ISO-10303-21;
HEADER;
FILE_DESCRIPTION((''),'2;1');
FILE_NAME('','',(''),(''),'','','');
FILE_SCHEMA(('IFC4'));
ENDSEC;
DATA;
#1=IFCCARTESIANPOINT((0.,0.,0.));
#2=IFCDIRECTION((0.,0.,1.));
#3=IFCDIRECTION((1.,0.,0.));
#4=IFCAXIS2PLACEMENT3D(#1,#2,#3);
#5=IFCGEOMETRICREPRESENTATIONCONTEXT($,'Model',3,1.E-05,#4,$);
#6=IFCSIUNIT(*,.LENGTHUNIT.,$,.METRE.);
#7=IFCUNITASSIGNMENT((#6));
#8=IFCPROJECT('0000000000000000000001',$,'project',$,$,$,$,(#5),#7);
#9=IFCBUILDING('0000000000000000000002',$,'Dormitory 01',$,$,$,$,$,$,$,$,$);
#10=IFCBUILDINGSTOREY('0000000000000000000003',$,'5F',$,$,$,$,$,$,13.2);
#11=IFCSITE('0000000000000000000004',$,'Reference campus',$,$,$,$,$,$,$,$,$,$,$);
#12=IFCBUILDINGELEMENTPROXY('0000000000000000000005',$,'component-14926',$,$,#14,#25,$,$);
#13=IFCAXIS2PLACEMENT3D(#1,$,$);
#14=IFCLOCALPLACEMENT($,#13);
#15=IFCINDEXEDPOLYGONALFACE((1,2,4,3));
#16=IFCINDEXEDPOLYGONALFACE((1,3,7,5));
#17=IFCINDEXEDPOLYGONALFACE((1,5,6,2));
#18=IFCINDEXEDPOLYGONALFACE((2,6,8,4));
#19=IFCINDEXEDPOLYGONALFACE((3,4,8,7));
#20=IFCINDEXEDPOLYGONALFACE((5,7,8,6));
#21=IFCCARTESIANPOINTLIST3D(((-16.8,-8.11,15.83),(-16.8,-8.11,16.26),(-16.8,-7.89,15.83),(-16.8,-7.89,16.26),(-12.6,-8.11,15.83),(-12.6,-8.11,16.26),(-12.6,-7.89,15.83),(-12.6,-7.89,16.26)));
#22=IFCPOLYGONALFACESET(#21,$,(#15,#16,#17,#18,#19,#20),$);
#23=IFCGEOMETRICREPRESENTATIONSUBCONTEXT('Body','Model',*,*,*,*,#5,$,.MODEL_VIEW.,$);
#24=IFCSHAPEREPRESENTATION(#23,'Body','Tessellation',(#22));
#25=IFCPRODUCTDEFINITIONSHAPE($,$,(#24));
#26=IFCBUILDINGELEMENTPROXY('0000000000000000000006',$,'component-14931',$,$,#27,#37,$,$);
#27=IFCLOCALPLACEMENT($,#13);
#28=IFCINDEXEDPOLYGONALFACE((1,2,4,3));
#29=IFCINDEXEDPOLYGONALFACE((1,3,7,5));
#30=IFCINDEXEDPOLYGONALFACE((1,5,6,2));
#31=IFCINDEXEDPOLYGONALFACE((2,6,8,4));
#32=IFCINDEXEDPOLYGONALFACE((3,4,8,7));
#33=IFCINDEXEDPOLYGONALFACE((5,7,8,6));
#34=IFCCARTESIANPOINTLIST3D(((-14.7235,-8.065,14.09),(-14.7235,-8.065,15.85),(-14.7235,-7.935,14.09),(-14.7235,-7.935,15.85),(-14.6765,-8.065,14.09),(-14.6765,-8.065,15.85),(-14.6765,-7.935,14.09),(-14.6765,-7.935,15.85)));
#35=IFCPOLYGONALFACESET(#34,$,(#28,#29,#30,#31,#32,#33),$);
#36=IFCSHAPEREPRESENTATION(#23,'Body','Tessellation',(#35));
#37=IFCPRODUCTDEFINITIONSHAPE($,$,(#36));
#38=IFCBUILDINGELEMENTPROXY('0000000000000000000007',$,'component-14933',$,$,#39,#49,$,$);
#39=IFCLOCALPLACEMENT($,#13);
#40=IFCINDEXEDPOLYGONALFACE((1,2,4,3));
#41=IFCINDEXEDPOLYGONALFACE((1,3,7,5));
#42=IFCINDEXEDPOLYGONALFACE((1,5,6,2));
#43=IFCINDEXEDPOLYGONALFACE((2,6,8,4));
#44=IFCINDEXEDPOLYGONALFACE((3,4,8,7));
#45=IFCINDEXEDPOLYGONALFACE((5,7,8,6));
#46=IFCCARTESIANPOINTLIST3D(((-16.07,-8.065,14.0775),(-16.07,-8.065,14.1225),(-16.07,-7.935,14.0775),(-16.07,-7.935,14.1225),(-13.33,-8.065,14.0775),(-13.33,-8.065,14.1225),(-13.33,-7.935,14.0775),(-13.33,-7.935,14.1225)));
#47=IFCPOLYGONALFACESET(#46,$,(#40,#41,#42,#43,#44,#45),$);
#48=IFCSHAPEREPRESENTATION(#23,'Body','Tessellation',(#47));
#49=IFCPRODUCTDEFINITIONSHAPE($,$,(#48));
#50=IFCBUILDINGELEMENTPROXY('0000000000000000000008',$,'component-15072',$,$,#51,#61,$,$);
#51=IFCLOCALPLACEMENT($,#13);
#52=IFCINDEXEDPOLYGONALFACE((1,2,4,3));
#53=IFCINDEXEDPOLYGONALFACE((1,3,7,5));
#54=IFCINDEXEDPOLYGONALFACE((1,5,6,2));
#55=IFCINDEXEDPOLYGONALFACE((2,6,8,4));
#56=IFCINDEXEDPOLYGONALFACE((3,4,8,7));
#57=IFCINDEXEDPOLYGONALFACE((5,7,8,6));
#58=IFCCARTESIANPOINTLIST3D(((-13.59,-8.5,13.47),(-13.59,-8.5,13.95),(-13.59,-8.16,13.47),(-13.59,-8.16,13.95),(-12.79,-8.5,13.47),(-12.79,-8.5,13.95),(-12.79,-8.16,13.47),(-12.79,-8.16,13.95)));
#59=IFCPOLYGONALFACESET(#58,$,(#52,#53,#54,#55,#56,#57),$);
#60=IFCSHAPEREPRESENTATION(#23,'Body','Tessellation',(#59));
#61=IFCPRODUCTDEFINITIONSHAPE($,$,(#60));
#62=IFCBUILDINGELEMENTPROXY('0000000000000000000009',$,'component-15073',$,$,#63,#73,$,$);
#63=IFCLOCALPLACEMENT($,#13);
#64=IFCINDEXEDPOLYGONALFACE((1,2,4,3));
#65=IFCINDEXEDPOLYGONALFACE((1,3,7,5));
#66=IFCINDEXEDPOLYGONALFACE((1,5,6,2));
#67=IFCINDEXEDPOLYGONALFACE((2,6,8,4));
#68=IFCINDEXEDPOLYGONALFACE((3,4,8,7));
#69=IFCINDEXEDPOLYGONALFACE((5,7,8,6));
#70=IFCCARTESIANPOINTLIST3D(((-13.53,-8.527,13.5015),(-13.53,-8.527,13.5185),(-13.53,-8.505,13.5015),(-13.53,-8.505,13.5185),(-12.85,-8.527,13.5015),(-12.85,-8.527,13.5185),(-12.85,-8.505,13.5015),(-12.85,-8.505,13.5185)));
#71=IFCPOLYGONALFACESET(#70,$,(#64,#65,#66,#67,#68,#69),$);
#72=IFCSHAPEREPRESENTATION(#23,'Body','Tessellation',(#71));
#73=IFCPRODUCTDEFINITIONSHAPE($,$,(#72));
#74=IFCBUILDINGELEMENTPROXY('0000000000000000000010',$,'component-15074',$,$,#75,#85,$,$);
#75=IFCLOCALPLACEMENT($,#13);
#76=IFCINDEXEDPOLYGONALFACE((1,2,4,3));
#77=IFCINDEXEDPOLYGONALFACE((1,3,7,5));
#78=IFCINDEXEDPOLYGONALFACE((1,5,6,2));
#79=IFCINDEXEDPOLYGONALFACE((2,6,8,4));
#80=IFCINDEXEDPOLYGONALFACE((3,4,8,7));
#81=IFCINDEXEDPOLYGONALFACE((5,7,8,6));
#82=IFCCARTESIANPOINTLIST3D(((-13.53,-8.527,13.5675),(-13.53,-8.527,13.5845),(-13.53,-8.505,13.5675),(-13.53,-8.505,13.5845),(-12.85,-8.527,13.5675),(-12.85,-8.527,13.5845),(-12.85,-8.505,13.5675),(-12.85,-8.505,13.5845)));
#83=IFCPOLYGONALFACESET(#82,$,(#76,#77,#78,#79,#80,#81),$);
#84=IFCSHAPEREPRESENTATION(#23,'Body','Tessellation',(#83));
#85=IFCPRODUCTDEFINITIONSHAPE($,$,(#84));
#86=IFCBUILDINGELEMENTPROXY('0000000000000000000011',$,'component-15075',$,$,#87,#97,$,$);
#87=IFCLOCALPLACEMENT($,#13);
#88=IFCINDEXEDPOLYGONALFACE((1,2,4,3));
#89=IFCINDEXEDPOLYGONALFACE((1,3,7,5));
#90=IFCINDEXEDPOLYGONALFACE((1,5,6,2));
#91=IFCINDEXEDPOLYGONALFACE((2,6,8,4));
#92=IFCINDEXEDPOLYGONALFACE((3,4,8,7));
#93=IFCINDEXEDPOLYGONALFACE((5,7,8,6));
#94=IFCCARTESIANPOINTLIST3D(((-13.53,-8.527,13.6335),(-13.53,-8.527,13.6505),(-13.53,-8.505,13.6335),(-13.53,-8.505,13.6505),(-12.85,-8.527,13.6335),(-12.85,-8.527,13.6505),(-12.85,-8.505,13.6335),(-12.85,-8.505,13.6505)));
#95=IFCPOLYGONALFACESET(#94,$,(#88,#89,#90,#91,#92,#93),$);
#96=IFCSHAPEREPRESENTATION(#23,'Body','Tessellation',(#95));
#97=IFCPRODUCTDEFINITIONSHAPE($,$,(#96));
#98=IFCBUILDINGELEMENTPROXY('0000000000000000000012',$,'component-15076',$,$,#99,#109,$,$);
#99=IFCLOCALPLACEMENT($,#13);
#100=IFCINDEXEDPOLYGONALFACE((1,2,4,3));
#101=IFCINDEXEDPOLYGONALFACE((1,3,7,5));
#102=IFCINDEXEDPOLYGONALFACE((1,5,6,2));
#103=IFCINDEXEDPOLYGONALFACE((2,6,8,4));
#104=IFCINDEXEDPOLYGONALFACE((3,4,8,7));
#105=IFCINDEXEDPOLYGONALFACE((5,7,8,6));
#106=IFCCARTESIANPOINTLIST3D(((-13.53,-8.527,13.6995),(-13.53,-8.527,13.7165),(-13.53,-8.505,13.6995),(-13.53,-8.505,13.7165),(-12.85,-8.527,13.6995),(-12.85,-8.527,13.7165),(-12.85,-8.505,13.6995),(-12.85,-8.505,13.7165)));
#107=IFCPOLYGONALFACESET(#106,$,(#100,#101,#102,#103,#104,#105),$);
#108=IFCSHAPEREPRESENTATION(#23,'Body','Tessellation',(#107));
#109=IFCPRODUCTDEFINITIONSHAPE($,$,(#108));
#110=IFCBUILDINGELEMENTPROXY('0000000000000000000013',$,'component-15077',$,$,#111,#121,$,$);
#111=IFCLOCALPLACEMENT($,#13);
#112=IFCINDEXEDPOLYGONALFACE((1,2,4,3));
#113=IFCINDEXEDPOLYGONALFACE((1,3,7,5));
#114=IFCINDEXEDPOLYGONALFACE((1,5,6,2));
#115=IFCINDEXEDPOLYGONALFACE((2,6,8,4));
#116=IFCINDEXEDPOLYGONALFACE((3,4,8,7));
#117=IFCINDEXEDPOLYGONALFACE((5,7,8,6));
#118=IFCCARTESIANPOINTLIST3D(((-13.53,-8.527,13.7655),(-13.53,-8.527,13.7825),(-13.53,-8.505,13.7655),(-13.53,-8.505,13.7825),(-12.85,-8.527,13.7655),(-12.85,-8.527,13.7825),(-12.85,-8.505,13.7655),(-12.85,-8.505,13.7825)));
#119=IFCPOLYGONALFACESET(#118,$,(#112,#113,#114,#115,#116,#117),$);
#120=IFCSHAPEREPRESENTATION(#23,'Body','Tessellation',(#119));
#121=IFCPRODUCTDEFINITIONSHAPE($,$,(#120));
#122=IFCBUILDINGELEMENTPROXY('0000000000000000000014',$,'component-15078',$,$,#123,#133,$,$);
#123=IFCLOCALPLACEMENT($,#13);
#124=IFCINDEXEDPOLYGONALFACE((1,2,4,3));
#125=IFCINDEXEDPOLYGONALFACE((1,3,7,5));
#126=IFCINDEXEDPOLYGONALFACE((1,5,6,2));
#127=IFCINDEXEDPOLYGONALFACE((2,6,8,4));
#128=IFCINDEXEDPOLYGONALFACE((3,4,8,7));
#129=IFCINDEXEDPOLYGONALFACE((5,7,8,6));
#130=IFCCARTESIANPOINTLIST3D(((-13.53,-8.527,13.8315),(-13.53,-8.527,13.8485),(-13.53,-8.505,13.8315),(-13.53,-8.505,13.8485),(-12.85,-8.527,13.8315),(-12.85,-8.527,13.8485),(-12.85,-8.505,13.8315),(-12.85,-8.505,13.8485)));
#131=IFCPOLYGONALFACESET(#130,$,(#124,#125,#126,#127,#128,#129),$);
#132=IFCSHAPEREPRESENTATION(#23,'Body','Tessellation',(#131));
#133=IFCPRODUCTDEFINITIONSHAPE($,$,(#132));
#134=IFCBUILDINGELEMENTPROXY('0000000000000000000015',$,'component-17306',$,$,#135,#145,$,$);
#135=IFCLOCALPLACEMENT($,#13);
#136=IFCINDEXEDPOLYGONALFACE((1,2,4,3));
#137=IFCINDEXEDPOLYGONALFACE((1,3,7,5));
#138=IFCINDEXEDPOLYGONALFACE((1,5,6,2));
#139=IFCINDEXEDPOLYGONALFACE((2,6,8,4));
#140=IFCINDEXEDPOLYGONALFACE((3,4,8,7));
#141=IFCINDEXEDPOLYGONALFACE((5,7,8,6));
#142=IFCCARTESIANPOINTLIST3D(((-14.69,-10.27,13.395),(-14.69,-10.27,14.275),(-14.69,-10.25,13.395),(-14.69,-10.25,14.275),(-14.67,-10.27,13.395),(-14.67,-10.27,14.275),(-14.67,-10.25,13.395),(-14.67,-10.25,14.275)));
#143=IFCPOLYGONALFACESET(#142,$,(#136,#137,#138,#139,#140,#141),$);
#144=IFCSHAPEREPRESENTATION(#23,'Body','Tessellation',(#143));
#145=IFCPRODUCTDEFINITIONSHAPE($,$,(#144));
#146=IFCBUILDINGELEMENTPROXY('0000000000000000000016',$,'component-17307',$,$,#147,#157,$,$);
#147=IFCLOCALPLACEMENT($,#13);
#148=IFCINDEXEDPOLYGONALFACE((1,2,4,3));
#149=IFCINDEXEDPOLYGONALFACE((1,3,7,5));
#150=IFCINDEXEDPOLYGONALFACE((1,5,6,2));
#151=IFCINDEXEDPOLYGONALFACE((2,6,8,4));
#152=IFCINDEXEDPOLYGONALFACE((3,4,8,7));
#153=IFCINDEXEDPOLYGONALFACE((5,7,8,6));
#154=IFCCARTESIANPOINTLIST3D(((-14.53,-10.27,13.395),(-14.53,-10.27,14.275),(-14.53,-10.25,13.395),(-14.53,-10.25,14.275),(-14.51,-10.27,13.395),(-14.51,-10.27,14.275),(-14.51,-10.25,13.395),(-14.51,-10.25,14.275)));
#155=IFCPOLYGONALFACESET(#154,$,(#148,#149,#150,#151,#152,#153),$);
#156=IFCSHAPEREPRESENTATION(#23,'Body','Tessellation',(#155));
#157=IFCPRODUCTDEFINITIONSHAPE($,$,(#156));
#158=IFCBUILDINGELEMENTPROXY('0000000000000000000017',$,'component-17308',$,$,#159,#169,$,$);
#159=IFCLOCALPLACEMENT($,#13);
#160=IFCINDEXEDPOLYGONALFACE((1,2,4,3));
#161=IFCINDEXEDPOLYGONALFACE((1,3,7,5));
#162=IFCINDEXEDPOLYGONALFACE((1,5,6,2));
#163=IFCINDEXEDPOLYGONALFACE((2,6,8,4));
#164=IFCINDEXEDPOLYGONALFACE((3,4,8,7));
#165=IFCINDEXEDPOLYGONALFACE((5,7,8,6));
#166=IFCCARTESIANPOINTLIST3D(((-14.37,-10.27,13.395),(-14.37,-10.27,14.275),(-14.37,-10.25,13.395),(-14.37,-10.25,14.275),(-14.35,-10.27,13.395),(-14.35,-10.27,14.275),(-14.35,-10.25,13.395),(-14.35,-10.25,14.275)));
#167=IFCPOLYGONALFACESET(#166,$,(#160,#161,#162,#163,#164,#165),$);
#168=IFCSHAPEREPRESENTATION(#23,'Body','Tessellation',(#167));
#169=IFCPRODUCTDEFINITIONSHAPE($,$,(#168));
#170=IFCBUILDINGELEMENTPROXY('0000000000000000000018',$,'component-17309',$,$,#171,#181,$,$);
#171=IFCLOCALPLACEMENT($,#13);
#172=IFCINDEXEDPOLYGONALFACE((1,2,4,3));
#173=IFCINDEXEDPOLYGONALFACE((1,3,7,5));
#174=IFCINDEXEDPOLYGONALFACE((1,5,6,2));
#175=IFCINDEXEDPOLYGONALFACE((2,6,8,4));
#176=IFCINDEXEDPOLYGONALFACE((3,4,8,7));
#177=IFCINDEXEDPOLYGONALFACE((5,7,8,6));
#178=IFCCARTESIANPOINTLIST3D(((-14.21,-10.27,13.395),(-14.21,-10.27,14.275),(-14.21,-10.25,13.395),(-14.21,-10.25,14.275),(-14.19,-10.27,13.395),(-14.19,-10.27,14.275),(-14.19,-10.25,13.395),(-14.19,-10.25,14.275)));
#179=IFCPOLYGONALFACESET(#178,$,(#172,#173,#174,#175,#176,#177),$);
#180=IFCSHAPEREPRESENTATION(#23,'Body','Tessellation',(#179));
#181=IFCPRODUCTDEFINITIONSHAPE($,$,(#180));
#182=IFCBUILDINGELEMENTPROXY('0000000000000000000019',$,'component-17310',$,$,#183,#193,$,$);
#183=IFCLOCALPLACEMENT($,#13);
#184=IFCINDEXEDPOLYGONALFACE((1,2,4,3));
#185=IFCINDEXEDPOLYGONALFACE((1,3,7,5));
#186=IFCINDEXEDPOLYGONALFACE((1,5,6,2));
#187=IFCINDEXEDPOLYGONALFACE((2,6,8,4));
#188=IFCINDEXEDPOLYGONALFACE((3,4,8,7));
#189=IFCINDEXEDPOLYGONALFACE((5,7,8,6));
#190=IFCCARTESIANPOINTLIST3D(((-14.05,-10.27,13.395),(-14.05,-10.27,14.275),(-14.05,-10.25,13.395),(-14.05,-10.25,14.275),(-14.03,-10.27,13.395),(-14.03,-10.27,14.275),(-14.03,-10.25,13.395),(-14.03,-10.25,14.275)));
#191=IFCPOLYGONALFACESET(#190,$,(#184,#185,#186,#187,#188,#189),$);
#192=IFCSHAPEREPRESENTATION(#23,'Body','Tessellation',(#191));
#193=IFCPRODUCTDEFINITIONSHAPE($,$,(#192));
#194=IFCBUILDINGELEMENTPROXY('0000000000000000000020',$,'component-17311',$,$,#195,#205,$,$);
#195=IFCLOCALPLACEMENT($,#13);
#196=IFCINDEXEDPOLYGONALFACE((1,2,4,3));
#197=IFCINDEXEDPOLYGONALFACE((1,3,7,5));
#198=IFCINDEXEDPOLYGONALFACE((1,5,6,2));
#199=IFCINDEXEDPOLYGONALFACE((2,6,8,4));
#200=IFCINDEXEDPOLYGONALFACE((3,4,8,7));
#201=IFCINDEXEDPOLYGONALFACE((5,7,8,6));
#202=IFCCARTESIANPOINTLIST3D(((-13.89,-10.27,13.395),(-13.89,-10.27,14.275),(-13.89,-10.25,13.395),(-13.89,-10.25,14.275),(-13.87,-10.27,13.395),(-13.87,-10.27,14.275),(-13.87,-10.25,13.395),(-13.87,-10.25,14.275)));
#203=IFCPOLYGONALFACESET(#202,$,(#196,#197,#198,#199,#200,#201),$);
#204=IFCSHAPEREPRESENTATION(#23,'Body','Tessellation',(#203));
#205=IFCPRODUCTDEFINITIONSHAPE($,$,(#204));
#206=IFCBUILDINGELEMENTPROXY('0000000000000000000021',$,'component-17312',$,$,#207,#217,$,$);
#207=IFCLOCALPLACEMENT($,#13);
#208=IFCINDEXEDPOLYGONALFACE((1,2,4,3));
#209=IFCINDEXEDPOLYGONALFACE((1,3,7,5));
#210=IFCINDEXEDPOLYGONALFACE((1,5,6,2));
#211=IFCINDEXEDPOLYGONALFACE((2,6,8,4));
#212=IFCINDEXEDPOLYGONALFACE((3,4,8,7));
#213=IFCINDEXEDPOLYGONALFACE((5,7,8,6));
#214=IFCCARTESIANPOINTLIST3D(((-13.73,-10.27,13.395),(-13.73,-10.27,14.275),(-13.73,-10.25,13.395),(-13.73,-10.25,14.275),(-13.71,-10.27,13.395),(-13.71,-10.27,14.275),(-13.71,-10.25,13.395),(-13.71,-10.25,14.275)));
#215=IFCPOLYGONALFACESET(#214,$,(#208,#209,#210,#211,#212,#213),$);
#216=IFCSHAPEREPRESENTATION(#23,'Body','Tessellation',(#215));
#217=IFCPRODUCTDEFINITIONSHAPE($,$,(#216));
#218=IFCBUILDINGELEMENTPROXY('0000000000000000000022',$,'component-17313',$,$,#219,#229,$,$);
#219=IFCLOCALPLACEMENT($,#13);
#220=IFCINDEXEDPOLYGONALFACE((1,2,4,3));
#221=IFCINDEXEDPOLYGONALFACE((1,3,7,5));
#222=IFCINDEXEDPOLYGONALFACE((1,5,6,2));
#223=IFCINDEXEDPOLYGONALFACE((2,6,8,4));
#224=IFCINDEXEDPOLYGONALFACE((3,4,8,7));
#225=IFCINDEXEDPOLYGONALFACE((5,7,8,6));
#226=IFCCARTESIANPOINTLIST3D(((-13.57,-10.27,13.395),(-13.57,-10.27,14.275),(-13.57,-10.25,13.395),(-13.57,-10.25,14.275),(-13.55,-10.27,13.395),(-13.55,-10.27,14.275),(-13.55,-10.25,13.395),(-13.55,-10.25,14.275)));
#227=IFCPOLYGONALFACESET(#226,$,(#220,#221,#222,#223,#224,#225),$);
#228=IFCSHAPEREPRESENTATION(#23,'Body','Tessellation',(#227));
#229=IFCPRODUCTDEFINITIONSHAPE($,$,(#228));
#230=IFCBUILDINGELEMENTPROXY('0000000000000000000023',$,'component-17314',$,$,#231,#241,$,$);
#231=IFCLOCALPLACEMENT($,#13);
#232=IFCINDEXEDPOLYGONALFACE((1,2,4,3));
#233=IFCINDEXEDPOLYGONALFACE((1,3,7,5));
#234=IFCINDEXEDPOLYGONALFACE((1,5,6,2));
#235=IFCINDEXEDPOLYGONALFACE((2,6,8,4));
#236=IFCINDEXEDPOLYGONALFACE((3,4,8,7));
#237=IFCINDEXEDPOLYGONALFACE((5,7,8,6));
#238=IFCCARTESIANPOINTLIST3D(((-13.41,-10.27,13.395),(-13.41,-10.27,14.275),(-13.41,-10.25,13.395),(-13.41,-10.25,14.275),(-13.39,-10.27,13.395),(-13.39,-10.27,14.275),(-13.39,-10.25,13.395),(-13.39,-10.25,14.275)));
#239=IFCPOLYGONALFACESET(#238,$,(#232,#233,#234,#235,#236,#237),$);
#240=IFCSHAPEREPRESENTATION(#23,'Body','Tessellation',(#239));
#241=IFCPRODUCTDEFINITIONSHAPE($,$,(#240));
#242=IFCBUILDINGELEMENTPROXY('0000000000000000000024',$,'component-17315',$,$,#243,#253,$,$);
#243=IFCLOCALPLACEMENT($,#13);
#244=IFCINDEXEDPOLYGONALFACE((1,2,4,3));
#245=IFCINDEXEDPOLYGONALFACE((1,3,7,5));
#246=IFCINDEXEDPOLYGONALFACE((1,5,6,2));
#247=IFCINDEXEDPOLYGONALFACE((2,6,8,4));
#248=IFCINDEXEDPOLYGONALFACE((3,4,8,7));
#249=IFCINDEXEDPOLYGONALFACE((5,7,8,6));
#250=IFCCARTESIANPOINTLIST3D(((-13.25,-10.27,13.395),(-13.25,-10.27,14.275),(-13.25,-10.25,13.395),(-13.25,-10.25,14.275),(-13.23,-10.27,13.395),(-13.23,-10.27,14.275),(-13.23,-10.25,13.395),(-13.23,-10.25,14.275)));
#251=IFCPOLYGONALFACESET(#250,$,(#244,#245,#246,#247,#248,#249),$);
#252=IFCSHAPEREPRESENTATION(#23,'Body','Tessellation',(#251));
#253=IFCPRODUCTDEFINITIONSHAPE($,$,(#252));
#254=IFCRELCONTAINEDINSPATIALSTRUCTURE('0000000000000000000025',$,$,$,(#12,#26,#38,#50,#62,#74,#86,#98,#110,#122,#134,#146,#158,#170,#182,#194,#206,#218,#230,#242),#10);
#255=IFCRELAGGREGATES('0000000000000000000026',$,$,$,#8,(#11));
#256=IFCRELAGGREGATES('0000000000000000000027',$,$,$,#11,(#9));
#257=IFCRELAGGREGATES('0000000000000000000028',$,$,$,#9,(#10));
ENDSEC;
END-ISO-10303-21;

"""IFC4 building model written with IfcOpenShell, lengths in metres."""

from ifc_helpers import new_model, si_unit, frame, origin, origin_with_axes, origin_2d, place, context, subcontext, project, spatial, rectangle, extrude, element, save


model = new_model("IFC4")

# Units and contexts
model_context = context("Model", 3, precision=1e-05, world=origin_with_axes())
body_context = subcontext(model_context, "Body", "Model", "MODEL_VIEW")
ifc_project = project(units=[si_unit("LENGTHUNIT", "METRE")], contexts=[model_context])

# Site, building, storey
site = spatial("IfcSite", under=ifc_project, Name="Reference campus")
building = spatial("IfcBuilding", under=site, Name="Dormitory 01")
storey = spatial("IfcBuildingStorey", under=building, Name="5F", Elevation=13.2)

# Building element proxies
proxy_1_placement = place(None, frame((-14.7, -8.0, 15.83), z_axis=(0.0, 0.0, 1.0), x_axis=(1.0, 0.0, 0.0)))
element("IfcBuildingElementProxy", 1, at=proxy_1_placement, inside=storey, Name="component-14926", context=body_context, shape_type="SweptSolid", body=[
    extrude(rectangle(XDim=4.2, YDim=0.22, at=origin_2d()), origin(), (0.0, 0.0, 1.0), 0.43),
])
proxy_2_placement = place(None, frame((-14.7, -8.0, 14.09), z_axis=(0.0, 0.0, 1.0), x_axis=(1.0, 0.0, 0.0)))
element("IfcBuildingElementProxy", 2, at=proxy_2_placement, inside=storey, Name="component-14931", context=body_context, shape_type="SweptSolid", body=[
    extrude(rectangle(XDim=0.047, YDim=0.13, at=origin_2d()), origin(), (0.0, 0.0, 1.0), 1.76),
])
proxy_3_placement = place(None, frame((-14.7, -8.0, 14.0775), z_axis=(0.0, 0.0, 1.0), x_axis=(1.0, 0.0, 0.0)))
element("IfcBuildingElementProxy", 3, at=proxy_3_placement, inside=storey, Name="component-14933", context=body_context, shape_type="SweptSolid", body=[
    extrude(rectangle(XDim=2.74, YDim=0.13, at=origin_2d()), origin(), (0.0, 0.0, 1.0), 0.045),
])
proxy_4_placement = place(None, frame((-13.19, -8.33, 13.47), z_axis=(0.0, 0.0, 1.0), x_axis=(1.0, 0.0, 0.0)))
element("IfcBuildingElementProxy", 4, at=proxy_4_placement, inside=storey, Name="component-15072", context=body_context, shape_type="SweptSolid", body=[
    extrude(rectangle(XDim=0.8, YDim=0.34, at=origin_2d()), origin(), (0.0, 0.0, 1.0), 0.48),
])
for number, where, z_axis, x_axis, name in (
    (5, (-13.19, -8.516, 13.5015), (0.0, 0.0, 1.0), (1.0, 0.0, 0.0), "component-15073"),
    (6, (-13.19, -8.516, 13.5675), (0.0, 0.0, 1.0), (1.0, 0.0, 0.0), "component-15074"),
    (7, (-13.19, -8.516, 13.6335), (0.0, 0.0, 1.0), (1.0, 0.0, 0.0), "component-15075"),
    (8, (-13.19, -8.516, 13.6995), (0.0, 0.0, 1.0), (1.0, 0.0, 0.0), "component-15076"),
    (9, (-13.19, -8.516, 13.7655), (0.0, 0.0, 1.0), (1.0, 0.0, 0.0), "component-15077"),
    (10, (-13.19, -8.516, 13.8315), (0.0, 0.0, 1.0), (1.0, 0.0, 0.0), "component-15078"),
):
    element("IfcBuildingElementProxy", number, at=place(None, frame(where, z_axis=z_axis, x_axis=x_axis)), inside=storey, Name=name, context=body_context, shape_type="SweptSolid", body=[
        extrude(rectangle(XDim=0.68, YDim=0.022, at=origin_2d()), origin(), (0.0, 0.0, 1.0), 0.017),
    ])
for number, where, z_axis, x_axis, name in (
    (11, (-14.68, -10.26, 13.395), (0.0, 0.0, 1.0), (1.0, 0.0, 0.0), "component-17306"),
    (12, (-14.52, -10.26, 13.395), (0.0, 0.0, 1.0), (1.0, 0.0, 0.0), "component-17307"),
    (13, (-14.36, -10.26, 13.395), (0.0, 0.0, 1.0), (1.0, 0.0, 0.0), "component-17308"),
    (14, (-14.2, -10.26, 13.395), (0.0, 0.0, 1.0), (1.0, 0.0, 0.0), "component-17309"),
    (15, (-14.04, -10.26, 13.395), (0.0, 0.0, 1.0), (1.0, 0.0, 0.0), "component-17310"),
    (16, (-13.88, -10.26, 13.395), (0.0, 0.0, 1.0), (1.0, 0.0, 0.0), "component-17311"),
    (17, (-13.72, -10.26, 13.395), (0.0, 0.0, 1.0), (1.0, 0.0, 0.0), "component-17312"),
    (18, (-13.56, -10.26, 13.395), (0.0, 0.0, 1.0), (1.0, 0.0, 0.0), "component-17313"),
    (19, (-13.4, -10.26, 13.395), (0.0, 0.0, 1.0), (1.0, 0.0, 0.0), "component-17314"),
    (20, (-13.24, -10.26, 13.395), (0.0, 0.0, 1.0), (1.0, 0.0, 0.0), "component-17315"),
):
    element("IfcBuildingElementProxy", number, at=place(None, frame(where, z_axis=z_axis, x_axis=x_axis)), inside=storey, Name=name, context=body_context, shape_type="SweptSolid", body=[
        extrude(rectangle(XDim=0.02, YDim=0.02, at=origin_2d()), origin(), (0.0, 0.0, 1.0), 0.88),
    ])

save(model, "model.ifc")
